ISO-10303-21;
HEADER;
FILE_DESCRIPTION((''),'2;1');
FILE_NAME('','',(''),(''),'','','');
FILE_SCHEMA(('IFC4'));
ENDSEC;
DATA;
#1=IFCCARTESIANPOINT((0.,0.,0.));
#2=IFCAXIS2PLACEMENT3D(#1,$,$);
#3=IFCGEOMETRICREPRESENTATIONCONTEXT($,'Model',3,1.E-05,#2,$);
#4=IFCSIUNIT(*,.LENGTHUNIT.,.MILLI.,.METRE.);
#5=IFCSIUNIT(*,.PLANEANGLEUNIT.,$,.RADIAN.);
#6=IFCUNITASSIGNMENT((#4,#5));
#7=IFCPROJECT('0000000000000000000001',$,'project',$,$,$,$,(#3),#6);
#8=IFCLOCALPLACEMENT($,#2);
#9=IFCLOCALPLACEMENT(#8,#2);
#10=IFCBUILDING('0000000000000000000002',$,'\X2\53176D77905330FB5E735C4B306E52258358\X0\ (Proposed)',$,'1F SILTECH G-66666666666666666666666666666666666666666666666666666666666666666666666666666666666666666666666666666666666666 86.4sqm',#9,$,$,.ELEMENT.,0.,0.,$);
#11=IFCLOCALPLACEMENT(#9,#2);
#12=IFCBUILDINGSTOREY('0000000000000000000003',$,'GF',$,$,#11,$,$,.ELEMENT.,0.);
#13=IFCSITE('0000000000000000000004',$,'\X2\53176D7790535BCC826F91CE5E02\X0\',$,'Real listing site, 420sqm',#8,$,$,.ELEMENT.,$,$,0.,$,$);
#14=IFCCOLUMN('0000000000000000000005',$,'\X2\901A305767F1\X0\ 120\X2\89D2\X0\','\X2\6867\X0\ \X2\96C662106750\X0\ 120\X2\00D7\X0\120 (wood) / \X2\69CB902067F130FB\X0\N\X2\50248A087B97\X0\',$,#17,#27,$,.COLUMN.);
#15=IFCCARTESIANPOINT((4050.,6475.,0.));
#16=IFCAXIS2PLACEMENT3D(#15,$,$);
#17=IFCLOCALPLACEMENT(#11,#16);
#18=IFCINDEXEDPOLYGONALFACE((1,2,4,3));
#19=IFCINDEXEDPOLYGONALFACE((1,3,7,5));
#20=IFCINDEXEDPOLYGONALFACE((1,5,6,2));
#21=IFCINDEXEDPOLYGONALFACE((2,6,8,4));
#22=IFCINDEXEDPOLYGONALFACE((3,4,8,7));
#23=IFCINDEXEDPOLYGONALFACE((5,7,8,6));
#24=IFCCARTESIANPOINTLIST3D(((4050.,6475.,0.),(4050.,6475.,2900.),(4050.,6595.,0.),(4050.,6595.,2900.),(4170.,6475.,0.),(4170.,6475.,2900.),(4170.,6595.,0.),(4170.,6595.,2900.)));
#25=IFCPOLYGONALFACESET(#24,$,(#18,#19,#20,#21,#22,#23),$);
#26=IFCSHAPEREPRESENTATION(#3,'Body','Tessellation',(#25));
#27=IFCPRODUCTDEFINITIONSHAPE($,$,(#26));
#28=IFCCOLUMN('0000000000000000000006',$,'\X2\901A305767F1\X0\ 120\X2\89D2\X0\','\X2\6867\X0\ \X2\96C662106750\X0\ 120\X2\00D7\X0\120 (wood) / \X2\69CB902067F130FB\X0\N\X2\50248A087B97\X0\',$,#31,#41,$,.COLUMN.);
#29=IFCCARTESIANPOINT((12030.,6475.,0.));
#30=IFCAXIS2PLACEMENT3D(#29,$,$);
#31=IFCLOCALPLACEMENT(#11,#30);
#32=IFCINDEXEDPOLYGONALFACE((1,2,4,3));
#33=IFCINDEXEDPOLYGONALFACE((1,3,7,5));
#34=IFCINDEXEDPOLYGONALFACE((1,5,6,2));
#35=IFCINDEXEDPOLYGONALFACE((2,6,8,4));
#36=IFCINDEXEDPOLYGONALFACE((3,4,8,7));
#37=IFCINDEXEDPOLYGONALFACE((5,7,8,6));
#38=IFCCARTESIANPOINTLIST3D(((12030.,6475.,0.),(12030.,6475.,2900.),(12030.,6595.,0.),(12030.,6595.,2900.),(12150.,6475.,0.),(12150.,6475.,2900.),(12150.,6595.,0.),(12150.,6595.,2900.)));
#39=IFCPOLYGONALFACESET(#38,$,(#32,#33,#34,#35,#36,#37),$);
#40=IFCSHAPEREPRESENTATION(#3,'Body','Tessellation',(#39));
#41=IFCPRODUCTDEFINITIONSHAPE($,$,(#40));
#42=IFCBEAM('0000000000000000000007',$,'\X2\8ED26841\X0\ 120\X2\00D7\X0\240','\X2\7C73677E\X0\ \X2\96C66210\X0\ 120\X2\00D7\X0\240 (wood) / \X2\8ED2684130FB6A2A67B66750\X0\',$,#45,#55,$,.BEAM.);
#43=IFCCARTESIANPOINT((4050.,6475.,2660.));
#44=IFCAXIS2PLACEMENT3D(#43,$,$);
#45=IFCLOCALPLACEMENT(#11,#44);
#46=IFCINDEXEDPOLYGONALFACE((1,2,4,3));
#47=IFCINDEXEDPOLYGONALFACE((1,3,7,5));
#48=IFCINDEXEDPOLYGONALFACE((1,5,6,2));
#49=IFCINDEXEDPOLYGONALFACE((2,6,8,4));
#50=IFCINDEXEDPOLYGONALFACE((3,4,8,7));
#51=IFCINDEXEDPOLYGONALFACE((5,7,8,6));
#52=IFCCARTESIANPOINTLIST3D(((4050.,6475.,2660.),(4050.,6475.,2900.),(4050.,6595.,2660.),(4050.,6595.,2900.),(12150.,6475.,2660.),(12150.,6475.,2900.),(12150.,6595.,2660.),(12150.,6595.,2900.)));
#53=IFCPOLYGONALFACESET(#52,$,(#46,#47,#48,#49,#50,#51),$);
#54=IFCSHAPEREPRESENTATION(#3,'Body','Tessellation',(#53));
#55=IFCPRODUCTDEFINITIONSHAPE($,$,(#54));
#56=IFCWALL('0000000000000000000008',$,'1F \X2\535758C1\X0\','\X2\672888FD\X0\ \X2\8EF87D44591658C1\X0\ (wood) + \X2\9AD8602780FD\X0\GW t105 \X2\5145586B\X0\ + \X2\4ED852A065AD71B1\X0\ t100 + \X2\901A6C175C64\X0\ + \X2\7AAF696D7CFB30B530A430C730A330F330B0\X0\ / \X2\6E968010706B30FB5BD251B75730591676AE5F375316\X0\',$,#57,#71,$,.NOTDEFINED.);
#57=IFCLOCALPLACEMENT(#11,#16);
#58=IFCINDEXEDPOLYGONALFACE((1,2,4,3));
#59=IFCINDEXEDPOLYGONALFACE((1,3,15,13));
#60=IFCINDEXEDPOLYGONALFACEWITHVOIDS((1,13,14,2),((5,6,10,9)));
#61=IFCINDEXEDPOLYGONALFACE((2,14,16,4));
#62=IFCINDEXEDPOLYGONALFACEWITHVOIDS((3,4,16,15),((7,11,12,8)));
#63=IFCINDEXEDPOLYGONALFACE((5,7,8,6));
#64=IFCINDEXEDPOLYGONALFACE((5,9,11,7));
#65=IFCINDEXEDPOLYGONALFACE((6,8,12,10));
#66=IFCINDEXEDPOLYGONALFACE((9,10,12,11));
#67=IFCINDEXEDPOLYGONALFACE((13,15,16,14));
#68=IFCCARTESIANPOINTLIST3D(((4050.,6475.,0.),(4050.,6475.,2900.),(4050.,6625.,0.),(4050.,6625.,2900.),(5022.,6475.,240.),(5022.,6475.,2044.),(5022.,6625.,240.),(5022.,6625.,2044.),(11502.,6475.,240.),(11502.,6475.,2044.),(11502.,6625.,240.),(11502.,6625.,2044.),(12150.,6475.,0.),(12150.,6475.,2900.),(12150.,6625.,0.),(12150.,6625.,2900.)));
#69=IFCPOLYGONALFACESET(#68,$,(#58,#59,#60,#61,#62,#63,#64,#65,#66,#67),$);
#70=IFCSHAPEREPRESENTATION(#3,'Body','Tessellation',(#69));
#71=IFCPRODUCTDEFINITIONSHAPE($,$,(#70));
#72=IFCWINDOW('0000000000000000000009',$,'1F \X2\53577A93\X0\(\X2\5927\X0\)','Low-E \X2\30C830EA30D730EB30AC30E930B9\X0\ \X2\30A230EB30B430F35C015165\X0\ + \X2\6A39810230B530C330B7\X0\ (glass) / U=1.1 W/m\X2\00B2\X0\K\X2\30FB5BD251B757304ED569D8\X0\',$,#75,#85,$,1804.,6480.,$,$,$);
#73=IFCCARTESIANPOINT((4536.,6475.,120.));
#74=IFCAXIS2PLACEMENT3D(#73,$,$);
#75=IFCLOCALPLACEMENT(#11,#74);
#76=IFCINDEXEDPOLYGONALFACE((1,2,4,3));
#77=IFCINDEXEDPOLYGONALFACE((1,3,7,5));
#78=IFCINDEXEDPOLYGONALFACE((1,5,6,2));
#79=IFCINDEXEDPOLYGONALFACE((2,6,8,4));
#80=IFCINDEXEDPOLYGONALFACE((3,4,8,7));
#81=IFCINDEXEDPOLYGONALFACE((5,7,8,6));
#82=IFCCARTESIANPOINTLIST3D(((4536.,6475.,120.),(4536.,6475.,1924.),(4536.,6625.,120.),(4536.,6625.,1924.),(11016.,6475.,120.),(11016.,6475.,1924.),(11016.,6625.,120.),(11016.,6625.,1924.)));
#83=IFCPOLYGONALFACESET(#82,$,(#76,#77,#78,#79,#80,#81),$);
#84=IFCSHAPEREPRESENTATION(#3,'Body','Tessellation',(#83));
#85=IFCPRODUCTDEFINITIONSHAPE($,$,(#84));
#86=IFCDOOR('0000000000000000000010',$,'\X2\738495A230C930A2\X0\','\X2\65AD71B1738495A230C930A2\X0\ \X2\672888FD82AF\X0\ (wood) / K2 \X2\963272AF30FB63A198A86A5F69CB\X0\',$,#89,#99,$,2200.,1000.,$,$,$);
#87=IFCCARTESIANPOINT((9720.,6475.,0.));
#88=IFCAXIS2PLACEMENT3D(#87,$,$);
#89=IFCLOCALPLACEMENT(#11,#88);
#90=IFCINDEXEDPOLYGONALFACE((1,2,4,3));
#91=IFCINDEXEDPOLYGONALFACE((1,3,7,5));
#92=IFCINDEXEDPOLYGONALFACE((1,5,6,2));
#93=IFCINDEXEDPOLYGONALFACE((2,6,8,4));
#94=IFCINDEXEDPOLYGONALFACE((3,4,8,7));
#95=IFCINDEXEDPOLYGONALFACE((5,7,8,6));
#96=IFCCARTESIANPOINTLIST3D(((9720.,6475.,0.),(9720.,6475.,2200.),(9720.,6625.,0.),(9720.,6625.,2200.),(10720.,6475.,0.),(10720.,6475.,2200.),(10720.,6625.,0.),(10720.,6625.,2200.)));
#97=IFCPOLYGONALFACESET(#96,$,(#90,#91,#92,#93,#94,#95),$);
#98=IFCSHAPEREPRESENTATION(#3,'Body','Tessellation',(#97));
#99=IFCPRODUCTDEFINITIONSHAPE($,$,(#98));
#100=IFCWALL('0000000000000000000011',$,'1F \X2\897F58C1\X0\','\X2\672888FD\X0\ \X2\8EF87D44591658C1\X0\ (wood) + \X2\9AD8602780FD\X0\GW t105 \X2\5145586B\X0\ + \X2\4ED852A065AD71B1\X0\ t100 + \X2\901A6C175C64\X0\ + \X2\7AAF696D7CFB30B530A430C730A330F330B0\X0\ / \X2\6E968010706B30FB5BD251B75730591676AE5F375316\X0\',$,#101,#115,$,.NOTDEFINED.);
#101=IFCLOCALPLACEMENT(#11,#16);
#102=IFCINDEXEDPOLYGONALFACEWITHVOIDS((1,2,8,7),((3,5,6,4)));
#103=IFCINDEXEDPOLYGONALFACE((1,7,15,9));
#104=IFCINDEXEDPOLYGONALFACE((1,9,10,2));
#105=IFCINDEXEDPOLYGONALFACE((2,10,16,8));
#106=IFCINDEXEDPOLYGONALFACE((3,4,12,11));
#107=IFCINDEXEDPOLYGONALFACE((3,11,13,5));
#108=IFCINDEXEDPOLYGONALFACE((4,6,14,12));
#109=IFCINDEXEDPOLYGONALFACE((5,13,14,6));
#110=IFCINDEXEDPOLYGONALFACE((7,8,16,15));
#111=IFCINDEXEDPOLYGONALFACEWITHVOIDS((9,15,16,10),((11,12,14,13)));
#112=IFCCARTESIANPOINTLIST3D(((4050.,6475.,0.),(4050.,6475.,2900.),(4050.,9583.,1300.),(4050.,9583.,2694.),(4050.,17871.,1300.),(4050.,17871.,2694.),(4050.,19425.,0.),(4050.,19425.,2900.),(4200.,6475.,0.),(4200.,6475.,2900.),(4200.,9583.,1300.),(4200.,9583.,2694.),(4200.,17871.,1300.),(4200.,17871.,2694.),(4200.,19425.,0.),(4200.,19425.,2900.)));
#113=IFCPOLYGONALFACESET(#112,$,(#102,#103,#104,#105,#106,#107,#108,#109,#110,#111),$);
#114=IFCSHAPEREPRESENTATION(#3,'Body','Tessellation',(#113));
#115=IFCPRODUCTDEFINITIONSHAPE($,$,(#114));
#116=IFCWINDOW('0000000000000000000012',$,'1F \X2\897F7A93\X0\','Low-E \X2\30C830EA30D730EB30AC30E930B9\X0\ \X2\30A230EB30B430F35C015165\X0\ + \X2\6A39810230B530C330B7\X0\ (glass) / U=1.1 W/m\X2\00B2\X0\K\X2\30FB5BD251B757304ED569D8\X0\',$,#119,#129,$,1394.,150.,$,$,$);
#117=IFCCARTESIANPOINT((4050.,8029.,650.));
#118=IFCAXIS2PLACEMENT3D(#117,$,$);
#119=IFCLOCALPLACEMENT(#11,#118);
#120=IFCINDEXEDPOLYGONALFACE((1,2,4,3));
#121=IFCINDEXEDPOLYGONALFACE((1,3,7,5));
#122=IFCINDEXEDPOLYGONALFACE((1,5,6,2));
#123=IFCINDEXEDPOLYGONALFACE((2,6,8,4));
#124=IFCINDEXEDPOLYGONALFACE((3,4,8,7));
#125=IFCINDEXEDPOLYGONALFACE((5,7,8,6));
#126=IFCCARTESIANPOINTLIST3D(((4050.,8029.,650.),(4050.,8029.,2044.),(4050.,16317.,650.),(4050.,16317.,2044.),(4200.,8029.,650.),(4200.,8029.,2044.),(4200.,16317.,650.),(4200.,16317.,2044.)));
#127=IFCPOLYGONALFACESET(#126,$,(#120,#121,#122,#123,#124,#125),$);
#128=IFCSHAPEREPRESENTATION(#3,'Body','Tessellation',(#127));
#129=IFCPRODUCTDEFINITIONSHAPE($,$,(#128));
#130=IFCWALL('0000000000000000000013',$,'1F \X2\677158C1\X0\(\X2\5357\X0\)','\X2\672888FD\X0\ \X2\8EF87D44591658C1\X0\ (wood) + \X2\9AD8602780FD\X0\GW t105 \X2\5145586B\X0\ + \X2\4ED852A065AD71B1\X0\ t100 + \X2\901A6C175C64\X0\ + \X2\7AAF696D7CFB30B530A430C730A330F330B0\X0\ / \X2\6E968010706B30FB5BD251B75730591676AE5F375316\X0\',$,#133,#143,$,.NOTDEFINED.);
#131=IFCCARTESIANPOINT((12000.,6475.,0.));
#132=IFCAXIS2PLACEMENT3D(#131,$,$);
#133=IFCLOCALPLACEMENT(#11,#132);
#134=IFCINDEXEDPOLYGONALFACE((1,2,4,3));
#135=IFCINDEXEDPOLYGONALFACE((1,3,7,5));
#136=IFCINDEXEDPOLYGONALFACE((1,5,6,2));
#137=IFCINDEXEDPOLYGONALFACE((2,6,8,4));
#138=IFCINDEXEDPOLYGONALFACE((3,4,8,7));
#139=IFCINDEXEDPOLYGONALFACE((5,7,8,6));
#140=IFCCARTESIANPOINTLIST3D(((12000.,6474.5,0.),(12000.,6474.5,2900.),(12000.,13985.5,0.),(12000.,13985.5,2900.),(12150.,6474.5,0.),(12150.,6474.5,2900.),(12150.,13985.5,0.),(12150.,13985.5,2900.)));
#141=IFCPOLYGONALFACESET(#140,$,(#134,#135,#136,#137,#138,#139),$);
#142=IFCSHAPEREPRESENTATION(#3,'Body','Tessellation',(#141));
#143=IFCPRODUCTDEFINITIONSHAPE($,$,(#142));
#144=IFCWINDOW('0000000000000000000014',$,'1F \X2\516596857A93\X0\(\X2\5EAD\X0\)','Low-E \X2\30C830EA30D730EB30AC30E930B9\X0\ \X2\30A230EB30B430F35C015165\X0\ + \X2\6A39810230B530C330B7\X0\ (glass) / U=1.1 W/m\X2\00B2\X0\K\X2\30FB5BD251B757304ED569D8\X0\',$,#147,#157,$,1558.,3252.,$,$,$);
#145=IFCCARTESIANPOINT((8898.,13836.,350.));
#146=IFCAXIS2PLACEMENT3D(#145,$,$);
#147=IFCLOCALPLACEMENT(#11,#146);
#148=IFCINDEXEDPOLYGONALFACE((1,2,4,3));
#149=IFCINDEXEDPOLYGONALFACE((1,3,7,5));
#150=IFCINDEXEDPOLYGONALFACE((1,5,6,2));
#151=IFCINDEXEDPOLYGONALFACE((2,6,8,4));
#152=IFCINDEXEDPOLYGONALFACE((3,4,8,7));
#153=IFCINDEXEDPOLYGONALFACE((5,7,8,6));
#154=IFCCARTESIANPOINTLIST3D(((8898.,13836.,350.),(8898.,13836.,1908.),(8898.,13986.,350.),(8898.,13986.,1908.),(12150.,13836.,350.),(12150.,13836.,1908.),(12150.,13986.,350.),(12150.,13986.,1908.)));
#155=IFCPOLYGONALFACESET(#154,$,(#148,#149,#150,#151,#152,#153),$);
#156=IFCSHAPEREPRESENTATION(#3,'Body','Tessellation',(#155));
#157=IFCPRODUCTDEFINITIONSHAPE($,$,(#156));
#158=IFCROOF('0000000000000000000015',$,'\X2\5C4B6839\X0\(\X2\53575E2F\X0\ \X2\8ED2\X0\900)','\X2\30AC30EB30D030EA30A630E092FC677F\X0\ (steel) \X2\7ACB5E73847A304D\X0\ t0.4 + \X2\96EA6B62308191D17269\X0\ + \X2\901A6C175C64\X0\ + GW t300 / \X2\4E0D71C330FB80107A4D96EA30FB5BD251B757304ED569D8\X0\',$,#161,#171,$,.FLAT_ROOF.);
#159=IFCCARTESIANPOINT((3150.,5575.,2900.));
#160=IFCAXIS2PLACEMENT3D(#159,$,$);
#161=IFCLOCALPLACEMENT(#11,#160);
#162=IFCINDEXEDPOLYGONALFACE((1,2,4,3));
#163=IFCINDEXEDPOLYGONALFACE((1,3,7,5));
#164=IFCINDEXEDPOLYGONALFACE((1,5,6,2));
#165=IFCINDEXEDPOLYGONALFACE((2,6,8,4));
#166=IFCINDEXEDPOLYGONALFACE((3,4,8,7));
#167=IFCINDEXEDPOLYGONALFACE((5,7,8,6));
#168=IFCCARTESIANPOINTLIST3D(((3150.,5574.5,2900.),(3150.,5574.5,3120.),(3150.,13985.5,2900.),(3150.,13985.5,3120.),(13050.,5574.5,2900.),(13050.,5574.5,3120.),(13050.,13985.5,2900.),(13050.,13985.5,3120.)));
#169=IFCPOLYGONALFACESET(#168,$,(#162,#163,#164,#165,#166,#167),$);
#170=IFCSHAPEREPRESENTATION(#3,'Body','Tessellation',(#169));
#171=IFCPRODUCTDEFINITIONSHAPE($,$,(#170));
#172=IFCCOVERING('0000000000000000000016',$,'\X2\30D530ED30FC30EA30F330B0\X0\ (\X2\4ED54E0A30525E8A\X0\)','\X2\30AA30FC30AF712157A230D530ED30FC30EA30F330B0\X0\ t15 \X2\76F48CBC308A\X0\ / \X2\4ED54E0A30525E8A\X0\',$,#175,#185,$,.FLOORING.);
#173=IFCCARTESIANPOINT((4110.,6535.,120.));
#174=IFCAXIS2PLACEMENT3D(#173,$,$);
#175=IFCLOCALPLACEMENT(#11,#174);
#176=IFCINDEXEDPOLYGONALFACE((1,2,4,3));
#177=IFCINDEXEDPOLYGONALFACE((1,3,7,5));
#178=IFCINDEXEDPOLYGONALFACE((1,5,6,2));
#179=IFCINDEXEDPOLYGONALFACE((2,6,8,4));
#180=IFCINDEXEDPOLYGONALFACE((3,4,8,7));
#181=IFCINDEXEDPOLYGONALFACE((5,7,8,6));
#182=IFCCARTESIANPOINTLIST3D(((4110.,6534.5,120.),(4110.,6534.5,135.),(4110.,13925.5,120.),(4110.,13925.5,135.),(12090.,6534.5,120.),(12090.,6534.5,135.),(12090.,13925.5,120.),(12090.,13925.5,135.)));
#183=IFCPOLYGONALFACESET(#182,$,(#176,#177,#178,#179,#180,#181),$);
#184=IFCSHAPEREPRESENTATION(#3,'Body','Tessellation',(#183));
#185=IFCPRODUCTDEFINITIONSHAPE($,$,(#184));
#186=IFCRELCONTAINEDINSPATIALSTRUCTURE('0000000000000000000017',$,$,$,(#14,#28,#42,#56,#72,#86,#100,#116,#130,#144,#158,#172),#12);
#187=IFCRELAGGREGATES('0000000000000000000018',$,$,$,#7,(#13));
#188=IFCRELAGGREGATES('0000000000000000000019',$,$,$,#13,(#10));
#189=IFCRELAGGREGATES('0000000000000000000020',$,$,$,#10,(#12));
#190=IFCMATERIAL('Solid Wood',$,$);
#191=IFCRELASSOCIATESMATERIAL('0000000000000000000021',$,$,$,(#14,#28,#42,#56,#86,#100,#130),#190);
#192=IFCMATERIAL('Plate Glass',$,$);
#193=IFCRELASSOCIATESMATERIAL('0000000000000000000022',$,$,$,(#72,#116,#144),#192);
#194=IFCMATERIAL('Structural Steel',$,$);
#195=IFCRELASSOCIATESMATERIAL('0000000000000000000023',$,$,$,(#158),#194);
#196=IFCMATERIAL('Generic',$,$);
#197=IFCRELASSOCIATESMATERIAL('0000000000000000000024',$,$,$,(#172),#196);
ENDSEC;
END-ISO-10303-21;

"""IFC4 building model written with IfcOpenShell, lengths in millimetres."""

from ifc_helpers import new_model, si_unit, frame, frame_2d, origin, place, context, project, spatial, rectangle, extrude, material, element, fill, save


model = new_model("IFC4")

# Units and contexts
model_context = context("Model", 3, precision=1e-05, world=origin())
ifc_project = project(units=[si_unit("LENGTHUNIT", "METRE", prefix="MILLI"), si_unit("PLANEANGLEUNIT", "RADIAN")], contexts=[model_context])

# Site, building, storey
site_placement = place(None, origin())
site = spatial("IfcSite", under=ifc_project, at=site_placement, Name="北海道富良野市", ObjectType="Real listing site, 420sqm", CompositionType="ELEMENT", RefElevation=0.0)
building_placement = place(site_placement, origin())
building = spatial("IfcBuilding", under=site, at=building_placement, Name="北海道・平屋の別荘 (Proposed)", ObjectType="1F SILTECH G-66666666666666666666666666666666666666666666666666666666666666666666666666666666666666666666666666666666666666 86.4sqm", CompositionType="ELEMENT", ElevationOfRefHeight=0.0, ElevationOfTerrain=0.0)
storey_placement = place(building_placement, origin())
storey = spatial("IfcBuildingStorey", under=building, at=storey_placement, Name="GF", CompositionType="ELEMENT", Elevation=0.0)

# Columns
ifc_material_1 = material(Name="Solid Wood")
column_1_placement = place(storey_placement, frame((4050.0, 6475.0, 0.0)))
element("IfcColumn", 1, at=column_1_placement, inside=storey, material=ifc_material_1, Name="通し柱 120角", Description="桧 集成材 120×120 (wood) / 構造柱・N値計算", PredefinedType="COLUMN", context=model_context, shape_type="SweptSolid", body=[
    extrude(rectangle(XDim=120.0, YDim=120.0, at=frame_2d((60.0, 60.0))), frame((4050.0, 6475.0, 0.0)), (0.0, 0.0, 1.0), 2900.0),
])
column_2_placement = place(storey_placement, frame((12030.0, 6475.0, 0.0)))
element("IfcColumn", 2, at=column_2_placement, inside=storey, material=ifc_material_1, Name="通し柱 120角", Description="桧 集成材 120×120 (wood) / 構造柱・N値計算", PredefinedType="COLUMN", context=model_context, shape_type="SweptSolid", body=[
    extrude(rectangle(XDim=120.0, YDim=120.0, at=frame_2d((60.0, 60.0))), frame((12030.0, 6475.0, 0.0)), (0.0, 0.0, 1.0), 2900.0),
])

# Beam
beam_1_placement = place(storey_placement, frame((4050.0, 6475.0, 2660.0)))
element("IfcBeam", 3, at=beam_1_placement, inside=storey, material=ifc_material_1, Name="軒桁 120×240", Description="米松 集成 120×240 (wood) / 軒桁・横架材", PredefinedType="BEAM", context=model_context, shape_type="SweptSolid", body=[
    extrude(rectangle(XDim=8100.0, YDim=120.0, at=frame_2d((4050.0, 60.0))), frame((4050.0, 6475.0, 2660.0)), (0.0, 0.0, 1.0), 240.0),
])

# Wall, openings, window, door
wall_1_placement = place(storey_placement, frame((4050.0, 6475.0, 0.0)))
wall_1 = element("IfcWall", 4, at=wall_1_placement, inside=storey, material=ifc_material_1, Name="1F 南壁", Description="木製 軸組外壁 (wood) + 高性能GW t105 充填 + 付加断熱 t100 + 通気層 + 窯業系サイディング / 準耐火・寒冷地外皮強化", PredefinedType="NOTDEFINED", context=model_context, shape_type="SweptSolid", body=[
    extrude(rectangle(XDim=8100.0, YDim=150.0, at=frame_2d((4050.0, 75.0))), frame((4050.0, 6475.0, 0.0)), (0.0, 0.0, 1.0), 2900.0),
])
opening_1_placement = place(storey_placement, frame((4536.0, 6475.0, 120.0)))
opening_1 = element("IfcOpeningElement", 5, at=opening_1_placement, cuts=wall_1, PredefinedType="NOTDEFINED", context=model_context, shape_type="SweptSolid", body=[
    extrude(rectangle(XDim=6480.0, YDim=150.0, at=frame_2d((3240.0, 75.0))), frame((4536.0, 6475.0, 120.0)), (0.0, 0.0, 1.0), 1804.0),
])
opening_2_placement = place(storey_placement, frame((9720.0, 6475.0, 0.0)))
opening_2 = element("IfcOpeningElement", 6, at=opening_2_placement, cuts=wall_1, PredefinedType="NOTDEFINED", context=model_context, shape_type="SweptSolid", body=[
    extrude(rectangle(XDim=1000.0, YDim=150.0, at=frame_2d((500.0, 75.0))), frame((9720.0, 6475.0, 0.0)), (0.0, 0.0, 1.0), 2200.0),
])
ifc_material_2 = material(Name="Plate Glass")
window_1_placement = place(storey_placement, frame((4536.0, 6475.0, 120.0)))
window_1 = element("IfcWindow", 7, at=window_1_placement, inside=storey, material=ifc_material_2, Name="1F 南窓(大)", Description="Low-E トリプルガラス アルゴン封入 + 樹脂サッシ (glass) / U=1.1 W/m²K・寒冷地仕様", OverallHeight=1804.0, OverallWidth=6480.0, context=model_context, shape_type="SweptSolid", body=[
    extrude(rectangle(XDim=6480.0, YDim=150.0, at=frame_2d((3240.0, 75.0))), frame((4536.0, 6475.0, 120.0)), (0.0, 0.0, 1.0), 1804.0),
])
fill(opening_1, window_1)
door_1_placement = place(storey_placement, frame((9720.0, 6475.0, 0.0)))
door_1 = element("IfcDoor", 8, at=door_1_placement, inside=storey, material=ifc_material_1, Name="玄関ドア", Description="断熱玄関ドア 木製芯 (wood) / K2 防犯・採風機構", OverallHeight=2200.0, OverallWidth=1000.0, context=model_context, shape_type="SweptSolid", body=[
    extrude(rectangle(XDim=1000.0, YDim=150.0, at=frame_2d((500.0, 75.0))), frame((9720.0, 6475.0, 0.0)), (0.0, 0.0, 1.0), 2200.0),
])
fill(opening_2, door_1)

# Walls, openings, windows
wall_2_placement = place(storey_placement, frame((4050.0, 6475.0, 0.0)))
wall_2 = element("IfcWall", 9, at=wall_2_placement, inside=storey, material=ifc_material_1, Name="1F 西壁", Description="木製 軸組外壁 (wood) + 高性能GW t105 充填 + 付加断熱 t100 + 通気層 + 窯業系サイディング / 準耐火・寒冷地外皮強化", PredefinedType="NOTDEFINED", context=model_context, shape_type="SweptSolid", body=[
    extrude(rectangle(XDim=150.0, YDim=12950.0, at=frame_2d((75.0, 6475.0))), frame((4050.0, 6475.0, 0.0)), (0.0, 0.0, 1.0), 2900.0),
])
opening_3_placement = place(storey_placement, frame((4050.0, 8029.0, 650.0)))
opening_3 = element("IfcOpeningElement", 10, at=opening_3_placement, cuts=wall_2, PredefinedType="NOTDEFINED", context=model_context, shape_type="SweptSolid", body=[
    extrude(rectangle(XDim=150.0, YDim=8288.0, at=frame_2d((75.0, 4144.0))), frame((4050.0, 8029.0, 650.0)), (0.0, 0.0, 1.0), 1394.0),
])
window_2_placement = place(storey_placement, frame((4050.0, 8029.0, 650.0)))
window_2 = element("IfcWindow", 11, at=window_2_placement, inside=storey, material=ifc_material_2, Name="1F 西窓", Description="Low-E トリプルガラス アルゴン封入 + 樹脂サッシ (glass) / U=1.1 W/m²K・寒冷地仕様", OverallHeight=1394.0, OverallWidth=150.0, context=model_context, shape_type="SweptSolid", body=[
    extrude(rectangle(XDim=150.0, YDim=8288.0, at=frame_2d((75.0, 4144.0))), frame((4050.0, 8029.0, 650.0)), (0.0, 0.0, 1.0), 1394.0),
])
fill(opening_3, window_2)
wall_3_placement = place(storey_placement, frame((12000.0, 6475.0, 0.0)))
wall_3 = element("IfcWall", 12, at=wall_3_placement, inside=storey, material=ifc_material_1, Name="1F 東壁(南)", Description="木製 軸組外壁 (wood) + 高性能GW t105 充填 + 付加断熱 t100 + 通気層 + 窯業系サイディング / 準耐火・寒冷地外皮強化", PredefinedType="NOTDEFINED", context=model_context, shape_type="SweptSolid", body=[
    extrude(rectangle(XDim=150.0, YDim=7511.0, at=frame_2d((75.0, 3755.0))), frame((12000.0, 6475.0, 0.0)), (0.0, 0.0, 1.0), 2900.0),
])
opening_4_placement = place(storey_placement, frame((8898.0, 13836.0, 350.0)))
opening_4 = element("IfcOpeningElement", 13, at=opening_4_placement, cuts=wall_3, PredefinedType="NOTDEFINED", context=model_context, shape_type="SweptSolid", body=[
    extrude(rectangle(XDim=3252.0, YDim=150.0, at=frame_2d((1626.0, 75.0))), frame((8898.0, 13836.0, 350.0)), (0.0, 0.0, 1.0), 1558.0),
])
window_3_placement = place(storey_placement, frame((8898.0, 13836.0, 350.0)))
window_3 = element("IfcWindow", 14, at=window_3_placement, inside=storey, material=ifc_material_2, Name="1F 入隅窓(庭)", Description="Low-E トリプルガラス アルゴン封入 + 樹脂サッシ (glass) / U=1.1 W/m²K・寒冷地仕様", OverallHeight=1558.0, OverallWidth=3252.0, context=model_context, shape_type="SweptSolid", body=[
    extrude(rectangle(XDim=3252.0, YDim=150.0, at=frame_2d((1626.0, 75.0))), frame((8898.0, 13836.0, 350.0)), (0.0, 0.0, 1.0), 1558.0),
])
fill(opening_4, window_3)

# Roof
ifc_material_3 = material(Name="Structural Steel")
roof_placement = place(storey_placement, frame((3150.0, 5575.0, 2900.0)))
element("IfcRoof", 15, at=roof_placement, inside=storey, material=ifc_material_3, Name="屋根(南帯 軒900)", Description="ガルバリウム鋼板 (steel) 立平葺き t0.4 + 雪止め金物 + 通気層 + GW t300 / 不燃・耐積雪・寒冷地仕様", PredefinedType="FLAT_ROOF", context=model_context, shape_type="SweptSolid", body=[
    extrude(rectangle(XDim=9900.0, YDim=8411.0, at=frame_2d((4950.0, 4205.0))), frame((3150.0, 5575.0, 2900.0)), (0.0, 0.0, 1.0), 220.0),
])

# Covering
ifc_material_4 = material(Name="Generic")
covering_1_placement = place(storey_placement, frame((4110.0, 6535.0, 120.0)))
element("IfcCovering", 16, at=covering_1_placement, inside=storey, material=ifc_material_4, Name="フローリング (仕上げ床)", Description="オーク無垢フローリング t15 直貼り / 仕上げ床", PredefinedType="FLOORING", context=model_context, shape_type="SweptSolid", body=[
    extrude(rectangle(XDim=7980.0, YDim=7391.0, at=frame_2d((3990.0, 3695.0))), frame((4110.0, 6535.0, 120.0)), (0.0, 0.0, 1.0), 15.0),
])

save(model, "model.ifc")
